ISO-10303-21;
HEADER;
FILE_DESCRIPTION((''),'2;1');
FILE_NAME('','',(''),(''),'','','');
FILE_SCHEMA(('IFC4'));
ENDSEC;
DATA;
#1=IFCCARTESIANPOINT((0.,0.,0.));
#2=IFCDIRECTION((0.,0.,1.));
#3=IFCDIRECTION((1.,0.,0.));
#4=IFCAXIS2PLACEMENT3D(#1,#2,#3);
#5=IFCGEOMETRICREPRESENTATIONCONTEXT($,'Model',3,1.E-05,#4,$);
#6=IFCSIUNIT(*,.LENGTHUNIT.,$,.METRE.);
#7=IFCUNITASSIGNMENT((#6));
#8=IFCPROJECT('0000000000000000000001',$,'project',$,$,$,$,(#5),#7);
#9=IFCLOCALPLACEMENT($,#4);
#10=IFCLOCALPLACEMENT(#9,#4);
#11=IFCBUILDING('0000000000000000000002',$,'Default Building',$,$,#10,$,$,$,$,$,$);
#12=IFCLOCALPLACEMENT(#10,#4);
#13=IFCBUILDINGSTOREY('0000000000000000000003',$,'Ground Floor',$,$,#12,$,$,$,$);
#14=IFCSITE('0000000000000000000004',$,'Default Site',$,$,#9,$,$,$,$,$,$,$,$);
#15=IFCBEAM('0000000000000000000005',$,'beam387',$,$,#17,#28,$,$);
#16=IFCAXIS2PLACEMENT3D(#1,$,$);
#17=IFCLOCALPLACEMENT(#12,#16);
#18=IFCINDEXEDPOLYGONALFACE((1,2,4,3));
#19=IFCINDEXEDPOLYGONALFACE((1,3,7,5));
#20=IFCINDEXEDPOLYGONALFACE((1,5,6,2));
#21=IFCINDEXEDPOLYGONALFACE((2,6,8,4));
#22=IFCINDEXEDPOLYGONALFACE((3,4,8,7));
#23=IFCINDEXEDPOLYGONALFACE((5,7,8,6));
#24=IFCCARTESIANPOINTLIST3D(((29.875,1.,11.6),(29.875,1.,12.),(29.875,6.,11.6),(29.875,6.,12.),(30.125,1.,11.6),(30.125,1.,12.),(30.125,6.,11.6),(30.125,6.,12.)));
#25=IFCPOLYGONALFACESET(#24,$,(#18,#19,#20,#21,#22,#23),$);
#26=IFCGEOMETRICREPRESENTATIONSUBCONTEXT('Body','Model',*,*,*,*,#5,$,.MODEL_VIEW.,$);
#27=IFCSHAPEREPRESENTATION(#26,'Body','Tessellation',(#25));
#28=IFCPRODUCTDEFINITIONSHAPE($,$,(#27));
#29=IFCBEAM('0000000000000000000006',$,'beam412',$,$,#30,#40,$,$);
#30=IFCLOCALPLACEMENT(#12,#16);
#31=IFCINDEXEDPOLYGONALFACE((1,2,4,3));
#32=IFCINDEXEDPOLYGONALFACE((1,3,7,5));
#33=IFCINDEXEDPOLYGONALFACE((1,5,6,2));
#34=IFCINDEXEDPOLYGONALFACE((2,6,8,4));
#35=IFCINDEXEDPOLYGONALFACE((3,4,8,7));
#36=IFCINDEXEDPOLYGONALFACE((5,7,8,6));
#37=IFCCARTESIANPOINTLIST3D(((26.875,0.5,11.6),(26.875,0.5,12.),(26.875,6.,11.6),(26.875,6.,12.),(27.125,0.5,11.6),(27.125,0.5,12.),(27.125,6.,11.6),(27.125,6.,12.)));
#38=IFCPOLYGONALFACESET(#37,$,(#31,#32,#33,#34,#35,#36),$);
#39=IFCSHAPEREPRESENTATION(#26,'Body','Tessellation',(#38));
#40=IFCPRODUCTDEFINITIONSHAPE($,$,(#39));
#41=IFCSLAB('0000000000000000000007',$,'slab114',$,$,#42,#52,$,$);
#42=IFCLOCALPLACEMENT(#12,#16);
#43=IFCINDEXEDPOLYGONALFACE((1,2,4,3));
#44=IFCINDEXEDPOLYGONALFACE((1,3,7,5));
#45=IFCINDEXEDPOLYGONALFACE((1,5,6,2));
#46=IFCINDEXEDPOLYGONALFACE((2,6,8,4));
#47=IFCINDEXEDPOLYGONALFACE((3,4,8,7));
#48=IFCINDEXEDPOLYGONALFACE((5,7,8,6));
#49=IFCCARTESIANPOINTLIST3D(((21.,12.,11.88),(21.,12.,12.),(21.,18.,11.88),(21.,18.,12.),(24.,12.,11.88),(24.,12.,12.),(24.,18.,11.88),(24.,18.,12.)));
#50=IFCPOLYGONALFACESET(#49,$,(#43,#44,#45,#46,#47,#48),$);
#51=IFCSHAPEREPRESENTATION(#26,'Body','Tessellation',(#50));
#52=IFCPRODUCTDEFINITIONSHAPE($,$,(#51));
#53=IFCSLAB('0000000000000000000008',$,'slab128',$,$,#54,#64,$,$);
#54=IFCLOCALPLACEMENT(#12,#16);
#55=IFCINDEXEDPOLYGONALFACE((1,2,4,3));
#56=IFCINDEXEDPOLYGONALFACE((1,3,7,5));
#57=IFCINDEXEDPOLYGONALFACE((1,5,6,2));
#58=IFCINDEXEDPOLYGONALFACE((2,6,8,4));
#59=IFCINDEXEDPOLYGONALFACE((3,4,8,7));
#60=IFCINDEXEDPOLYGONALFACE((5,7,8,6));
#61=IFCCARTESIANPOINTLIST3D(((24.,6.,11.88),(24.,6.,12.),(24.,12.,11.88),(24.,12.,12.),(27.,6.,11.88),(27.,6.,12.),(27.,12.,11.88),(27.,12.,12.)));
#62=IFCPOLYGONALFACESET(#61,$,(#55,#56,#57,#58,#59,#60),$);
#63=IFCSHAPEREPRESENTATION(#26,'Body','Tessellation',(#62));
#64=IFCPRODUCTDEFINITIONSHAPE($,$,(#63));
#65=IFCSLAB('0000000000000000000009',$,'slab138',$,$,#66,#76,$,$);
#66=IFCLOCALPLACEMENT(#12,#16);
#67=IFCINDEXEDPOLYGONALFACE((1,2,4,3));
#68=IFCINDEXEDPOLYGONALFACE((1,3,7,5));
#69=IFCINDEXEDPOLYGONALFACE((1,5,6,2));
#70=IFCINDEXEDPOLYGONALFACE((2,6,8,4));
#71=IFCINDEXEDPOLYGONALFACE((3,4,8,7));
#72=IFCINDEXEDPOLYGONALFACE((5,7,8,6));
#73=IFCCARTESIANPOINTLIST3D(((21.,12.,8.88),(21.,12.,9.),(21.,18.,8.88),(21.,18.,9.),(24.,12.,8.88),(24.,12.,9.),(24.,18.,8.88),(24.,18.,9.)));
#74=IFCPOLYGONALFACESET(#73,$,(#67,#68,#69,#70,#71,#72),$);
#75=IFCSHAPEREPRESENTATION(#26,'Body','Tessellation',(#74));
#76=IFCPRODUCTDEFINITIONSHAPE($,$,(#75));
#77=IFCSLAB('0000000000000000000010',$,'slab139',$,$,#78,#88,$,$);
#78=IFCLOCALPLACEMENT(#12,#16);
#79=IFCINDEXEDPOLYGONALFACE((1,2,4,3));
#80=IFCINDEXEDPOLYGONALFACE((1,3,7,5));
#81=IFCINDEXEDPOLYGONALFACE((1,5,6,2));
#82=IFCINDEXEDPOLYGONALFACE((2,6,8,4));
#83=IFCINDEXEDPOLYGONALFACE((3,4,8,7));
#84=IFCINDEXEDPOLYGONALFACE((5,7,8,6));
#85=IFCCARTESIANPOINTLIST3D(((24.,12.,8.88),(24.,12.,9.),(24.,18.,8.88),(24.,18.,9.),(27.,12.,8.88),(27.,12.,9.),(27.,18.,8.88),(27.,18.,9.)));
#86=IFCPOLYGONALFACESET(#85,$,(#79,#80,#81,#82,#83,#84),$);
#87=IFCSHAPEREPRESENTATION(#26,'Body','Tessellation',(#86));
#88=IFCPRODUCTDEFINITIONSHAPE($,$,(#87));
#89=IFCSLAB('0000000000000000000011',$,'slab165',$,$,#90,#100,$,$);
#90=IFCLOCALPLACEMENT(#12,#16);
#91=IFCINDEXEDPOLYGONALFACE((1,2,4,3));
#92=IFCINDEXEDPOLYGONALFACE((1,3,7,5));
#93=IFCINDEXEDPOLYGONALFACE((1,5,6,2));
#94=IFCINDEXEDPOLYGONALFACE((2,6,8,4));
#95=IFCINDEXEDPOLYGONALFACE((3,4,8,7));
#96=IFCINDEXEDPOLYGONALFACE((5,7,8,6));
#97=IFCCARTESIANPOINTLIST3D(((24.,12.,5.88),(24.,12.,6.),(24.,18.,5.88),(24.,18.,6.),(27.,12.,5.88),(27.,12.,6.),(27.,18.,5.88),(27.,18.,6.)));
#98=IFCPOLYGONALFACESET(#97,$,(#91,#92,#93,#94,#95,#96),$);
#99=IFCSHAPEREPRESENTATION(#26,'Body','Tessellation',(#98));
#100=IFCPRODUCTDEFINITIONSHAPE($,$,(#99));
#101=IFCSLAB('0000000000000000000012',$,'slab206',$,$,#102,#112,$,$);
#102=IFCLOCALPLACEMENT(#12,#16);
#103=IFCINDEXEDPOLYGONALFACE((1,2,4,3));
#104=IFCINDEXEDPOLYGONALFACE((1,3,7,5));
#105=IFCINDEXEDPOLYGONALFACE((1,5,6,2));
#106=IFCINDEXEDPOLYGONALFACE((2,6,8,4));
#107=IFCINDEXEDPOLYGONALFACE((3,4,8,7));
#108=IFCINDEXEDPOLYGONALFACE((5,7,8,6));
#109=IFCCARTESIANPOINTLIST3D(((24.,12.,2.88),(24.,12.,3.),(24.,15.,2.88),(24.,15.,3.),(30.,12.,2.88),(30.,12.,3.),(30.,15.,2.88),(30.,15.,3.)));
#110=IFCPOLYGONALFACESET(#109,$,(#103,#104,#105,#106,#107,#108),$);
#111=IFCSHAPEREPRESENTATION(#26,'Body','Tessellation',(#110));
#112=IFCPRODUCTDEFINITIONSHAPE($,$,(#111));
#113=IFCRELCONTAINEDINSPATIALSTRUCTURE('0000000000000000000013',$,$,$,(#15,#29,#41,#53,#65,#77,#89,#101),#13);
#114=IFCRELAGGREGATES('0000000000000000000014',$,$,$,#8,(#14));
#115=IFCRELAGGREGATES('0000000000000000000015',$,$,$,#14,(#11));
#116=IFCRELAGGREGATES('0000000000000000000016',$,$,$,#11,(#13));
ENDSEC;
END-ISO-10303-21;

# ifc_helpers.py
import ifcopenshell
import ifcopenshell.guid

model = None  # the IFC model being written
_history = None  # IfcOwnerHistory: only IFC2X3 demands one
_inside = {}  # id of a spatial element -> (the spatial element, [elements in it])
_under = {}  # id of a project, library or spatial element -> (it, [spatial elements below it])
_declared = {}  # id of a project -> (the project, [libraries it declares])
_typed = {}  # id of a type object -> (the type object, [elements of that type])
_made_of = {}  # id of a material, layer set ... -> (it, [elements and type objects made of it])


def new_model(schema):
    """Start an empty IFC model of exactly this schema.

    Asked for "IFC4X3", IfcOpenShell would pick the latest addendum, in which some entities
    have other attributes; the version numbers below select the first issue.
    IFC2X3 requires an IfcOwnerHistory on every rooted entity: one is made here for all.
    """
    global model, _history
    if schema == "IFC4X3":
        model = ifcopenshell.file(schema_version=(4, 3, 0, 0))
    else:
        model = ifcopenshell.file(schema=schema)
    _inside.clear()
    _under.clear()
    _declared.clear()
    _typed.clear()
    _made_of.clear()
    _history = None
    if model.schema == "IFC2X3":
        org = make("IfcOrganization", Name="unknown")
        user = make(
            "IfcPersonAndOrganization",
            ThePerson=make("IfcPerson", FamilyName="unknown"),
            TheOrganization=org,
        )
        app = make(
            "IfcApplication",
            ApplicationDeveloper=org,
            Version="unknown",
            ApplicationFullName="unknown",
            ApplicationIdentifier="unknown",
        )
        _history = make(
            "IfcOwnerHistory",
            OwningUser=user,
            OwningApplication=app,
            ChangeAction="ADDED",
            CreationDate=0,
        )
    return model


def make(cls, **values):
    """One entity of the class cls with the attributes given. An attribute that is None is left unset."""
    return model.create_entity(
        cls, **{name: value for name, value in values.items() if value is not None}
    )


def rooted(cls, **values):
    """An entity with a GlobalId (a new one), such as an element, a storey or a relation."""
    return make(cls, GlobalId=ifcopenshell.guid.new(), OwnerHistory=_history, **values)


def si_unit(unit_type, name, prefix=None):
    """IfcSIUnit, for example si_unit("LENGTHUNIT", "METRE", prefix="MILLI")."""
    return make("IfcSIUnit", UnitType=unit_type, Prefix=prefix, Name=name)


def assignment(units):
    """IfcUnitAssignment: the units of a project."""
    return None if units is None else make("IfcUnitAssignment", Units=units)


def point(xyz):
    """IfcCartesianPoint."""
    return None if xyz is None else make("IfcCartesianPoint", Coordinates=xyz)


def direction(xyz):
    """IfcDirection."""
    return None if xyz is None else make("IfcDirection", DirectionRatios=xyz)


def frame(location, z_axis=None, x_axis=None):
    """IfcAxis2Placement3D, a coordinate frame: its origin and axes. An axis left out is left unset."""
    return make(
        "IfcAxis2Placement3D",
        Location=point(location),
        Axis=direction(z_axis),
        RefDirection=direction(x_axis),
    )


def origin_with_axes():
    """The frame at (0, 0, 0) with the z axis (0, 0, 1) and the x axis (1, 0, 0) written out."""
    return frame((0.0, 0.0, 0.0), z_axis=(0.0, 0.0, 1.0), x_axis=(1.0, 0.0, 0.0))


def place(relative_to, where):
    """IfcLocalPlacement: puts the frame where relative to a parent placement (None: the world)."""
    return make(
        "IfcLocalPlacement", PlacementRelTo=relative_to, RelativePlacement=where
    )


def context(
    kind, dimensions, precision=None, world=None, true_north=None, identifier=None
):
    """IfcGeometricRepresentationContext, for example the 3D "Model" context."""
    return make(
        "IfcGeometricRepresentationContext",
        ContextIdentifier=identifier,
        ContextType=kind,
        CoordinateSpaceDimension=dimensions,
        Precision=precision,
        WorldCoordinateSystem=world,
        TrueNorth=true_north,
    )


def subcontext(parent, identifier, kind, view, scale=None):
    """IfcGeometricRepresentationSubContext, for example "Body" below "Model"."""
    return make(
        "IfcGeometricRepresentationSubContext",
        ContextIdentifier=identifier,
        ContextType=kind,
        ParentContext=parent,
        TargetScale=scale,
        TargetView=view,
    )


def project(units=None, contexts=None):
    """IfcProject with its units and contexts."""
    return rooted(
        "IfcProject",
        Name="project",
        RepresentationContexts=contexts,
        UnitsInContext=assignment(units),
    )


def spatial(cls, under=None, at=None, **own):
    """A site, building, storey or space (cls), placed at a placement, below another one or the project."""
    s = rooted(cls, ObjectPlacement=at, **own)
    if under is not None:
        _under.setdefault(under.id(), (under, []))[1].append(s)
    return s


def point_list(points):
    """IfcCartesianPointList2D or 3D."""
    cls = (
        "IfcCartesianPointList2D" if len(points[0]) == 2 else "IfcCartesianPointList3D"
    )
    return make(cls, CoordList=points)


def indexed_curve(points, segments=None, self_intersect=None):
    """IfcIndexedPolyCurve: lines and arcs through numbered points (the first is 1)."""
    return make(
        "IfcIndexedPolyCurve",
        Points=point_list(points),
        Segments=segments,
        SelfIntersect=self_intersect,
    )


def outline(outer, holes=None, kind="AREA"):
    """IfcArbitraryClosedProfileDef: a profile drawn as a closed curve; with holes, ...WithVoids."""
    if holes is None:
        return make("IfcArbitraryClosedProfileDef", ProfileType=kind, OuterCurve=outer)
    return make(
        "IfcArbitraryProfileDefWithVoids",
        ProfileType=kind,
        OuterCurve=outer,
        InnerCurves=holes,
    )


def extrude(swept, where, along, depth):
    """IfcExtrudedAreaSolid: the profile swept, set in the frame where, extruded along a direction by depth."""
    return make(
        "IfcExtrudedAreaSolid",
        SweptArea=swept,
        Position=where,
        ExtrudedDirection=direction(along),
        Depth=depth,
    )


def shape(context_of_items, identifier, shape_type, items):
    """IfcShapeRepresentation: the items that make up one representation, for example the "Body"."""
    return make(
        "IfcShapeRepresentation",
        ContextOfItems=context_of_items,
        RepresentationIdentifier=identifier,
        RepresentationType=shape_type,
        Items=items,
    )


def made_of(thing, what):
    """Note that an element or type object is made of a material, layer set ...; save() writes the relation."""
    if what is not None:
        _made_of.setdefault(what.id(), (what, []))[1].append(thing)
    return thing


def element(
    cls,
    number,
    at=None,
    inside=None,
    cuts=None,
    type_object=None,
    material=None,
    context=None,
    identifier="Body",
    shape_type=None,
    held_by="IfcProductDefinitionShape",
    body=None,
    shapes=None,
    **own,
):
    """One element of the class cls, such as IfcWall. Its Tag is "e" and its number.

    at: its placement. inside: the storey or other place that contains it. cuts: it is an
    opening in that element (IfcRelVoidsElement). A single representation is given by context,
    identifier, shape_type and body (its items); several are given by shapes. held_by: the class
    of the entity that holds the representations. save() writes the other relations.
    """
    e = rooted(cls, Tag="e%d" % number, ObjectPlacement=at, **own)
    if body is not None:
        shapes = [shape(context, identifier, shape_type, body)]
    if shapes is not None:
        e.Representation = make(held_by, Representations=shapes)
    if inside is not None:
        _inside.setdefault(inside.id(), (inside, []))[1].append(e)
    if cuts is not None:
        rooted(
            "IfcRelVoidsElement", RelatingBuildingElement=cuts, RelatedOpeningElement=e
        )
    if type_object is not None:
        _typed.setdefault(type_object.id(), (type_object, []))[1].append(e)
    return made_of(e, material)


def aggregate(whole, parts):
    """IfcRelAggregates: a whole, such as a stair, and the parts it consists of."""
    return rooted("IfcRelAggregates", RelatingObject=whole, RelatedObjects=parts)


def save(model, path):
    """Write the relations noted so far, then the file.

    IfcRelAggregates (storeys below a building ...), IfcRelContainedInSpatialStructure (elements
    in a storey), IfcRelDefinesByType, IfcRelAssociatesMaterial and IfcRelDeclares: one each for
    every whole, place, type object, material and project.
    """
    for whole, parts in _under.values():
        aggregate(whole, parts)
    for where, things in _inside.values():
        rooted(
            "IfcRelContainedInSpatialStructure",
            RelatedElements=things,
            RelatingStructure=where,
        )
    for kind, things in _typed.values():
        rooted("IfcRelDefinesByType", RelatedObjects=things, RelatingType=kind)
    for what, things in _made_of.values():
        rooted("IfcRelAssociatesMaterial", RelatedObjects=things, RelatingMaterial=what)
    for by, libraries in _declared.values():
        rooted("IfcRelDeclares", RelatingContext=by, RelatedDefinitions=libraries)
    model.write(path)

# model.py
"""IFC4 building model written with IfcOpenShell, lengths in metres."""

from ifc_helpers import new_model, si_unit, frame, origin_with_axes, place, context, subcontext, project, spatial, indexed_curve, outline, extrude, element, save


model = new_model("IFC4")

# Units and contexts
model_context = context("Model", 3, precision=1e-05, world=origin_with_axes())
body_context = subcontext(model_context, "Body", "Model", "MODEL_VIEW")
ifc_project = project(units=[si_unit("LENGTHUNIT", "METRE")], contexts=[model_context])

# Site, building, storey
site_placement = place(None, origin_with_axes())
site = spatial("IfcSite", under=ifc_project, at=site_placement, Name="Default Site")
building_placement = place(site_placement, origin_with_axes())
building = spatial("IfcBuilding", under=site, at=building_placement, Name="Default Building")
storey_placement = place(building_placement, origin_with_axes())
storey = spatial("IfcBuildingStorey", under=building, at=storey_placement, Name="Ground Floor")

# Beams
beam_1_placement = place(storey_placement, frame((29.875, 6.0, 11.6), z_axis=(0.0, 0.0, 1.0), x_axis=(0.0, -1.0, 0.0)))
element("IfcBeam", 1, at=beam_1_placement, inside=storey, Name="beam387", context=body_context, shape_type="SweptSolid", body=[
    extrude(outline(indexed_curve([(0.0, 0.0), (0.0, 0.25), (5.0, 0.25), (5.0, 0.0), (0.0, 0.0)], self_intersect=False)), origin_with_axes(), (0.0, 0.0, 1.0), 0.4),
])
beam_2_placement = place(storey_placement, frame((26.875, 6.0, 11.6), z_axis=(0.0, 0.0, 1.0), x_axis=(0.0, -1.0, 0.0)))
element("IfcBeam", 2, at=beam_2_placement, inside=storey, Name="beam412", context=body_context, shape_type="SweptSolid", body=[
    extrude(outline(indexed_curve([(0.0, 0.0), (0.0, 0.25), (5.5, 0.25), (5.5, 0.0), (0.0, 0.0)], self_intersect=False)), origin_with_axes(), (0.0, 0.0, 1.0), 0.4),
])

# Slabs
for number, where, z_axis, x_axis, name in (
    (3, (21.0, 12.0, 11.88), (0.0, 0.0, 1.0), (1.0, 0.0, 0.0), "slab114"),
    (4, (24.0, 6.0, 11.88), (0.0, 0.0, 1.0), (1.0, 0.0, 0.0), "slab128"),
    (5, (21.0, 12.0, 8.88), (0.0, 0.0, 1.0), (1.0, 0.0, 0.0), "slab138"),
    (6, (24.0, 12.0, 8.88), (0.0, 0.0, 1.0), (1.0, 0.0, 0.0), "slab139"),
    (7, (24.0, 12.0, 5.88), (0.0, 0.0, 1.0), (1.0, 0.0, 0.0), "slab165"),
):
    element("IfcSlab", number, at=place(storey_placement, frame(where, z_axis=z_axis, x_axis=x_axis)), inside=storey, Name=name, context=body_context, shape_type="SweptSolid", body=[
        extrude(outline(indexed_curve([(0.0, 0.0), (0.0, 6.0), (3.0, 6.0), (3.0, 0.0), (0.0, 0.0)], self_intersect=False)), origin_with_axes(), (0.0, 0.0, 1.0), 0.12),
    ])
slab_placement = place(storey_placement, frame((24.0, 12.0, 2.88), z_axis=(0.0, 0.0, 1.0), x_axis=(1.0, 0.0, 0.0)))
element("IfcSlab", 8, at=slab_placement, inside=storey, Name="slab206", context=body_context, shape_type="SweptSolid", body=[
    extrude(outline(indexed_curve([(0.0, 0.0), (0.0, 3.0), (6.0, 3.0), (6.0, 0.0), (0.0, 0.0)], self_intersect=False)), origin_with_axes(), (0.0, 0.0, 1.0), 0.12),
])

save(model, "model.ifc")
